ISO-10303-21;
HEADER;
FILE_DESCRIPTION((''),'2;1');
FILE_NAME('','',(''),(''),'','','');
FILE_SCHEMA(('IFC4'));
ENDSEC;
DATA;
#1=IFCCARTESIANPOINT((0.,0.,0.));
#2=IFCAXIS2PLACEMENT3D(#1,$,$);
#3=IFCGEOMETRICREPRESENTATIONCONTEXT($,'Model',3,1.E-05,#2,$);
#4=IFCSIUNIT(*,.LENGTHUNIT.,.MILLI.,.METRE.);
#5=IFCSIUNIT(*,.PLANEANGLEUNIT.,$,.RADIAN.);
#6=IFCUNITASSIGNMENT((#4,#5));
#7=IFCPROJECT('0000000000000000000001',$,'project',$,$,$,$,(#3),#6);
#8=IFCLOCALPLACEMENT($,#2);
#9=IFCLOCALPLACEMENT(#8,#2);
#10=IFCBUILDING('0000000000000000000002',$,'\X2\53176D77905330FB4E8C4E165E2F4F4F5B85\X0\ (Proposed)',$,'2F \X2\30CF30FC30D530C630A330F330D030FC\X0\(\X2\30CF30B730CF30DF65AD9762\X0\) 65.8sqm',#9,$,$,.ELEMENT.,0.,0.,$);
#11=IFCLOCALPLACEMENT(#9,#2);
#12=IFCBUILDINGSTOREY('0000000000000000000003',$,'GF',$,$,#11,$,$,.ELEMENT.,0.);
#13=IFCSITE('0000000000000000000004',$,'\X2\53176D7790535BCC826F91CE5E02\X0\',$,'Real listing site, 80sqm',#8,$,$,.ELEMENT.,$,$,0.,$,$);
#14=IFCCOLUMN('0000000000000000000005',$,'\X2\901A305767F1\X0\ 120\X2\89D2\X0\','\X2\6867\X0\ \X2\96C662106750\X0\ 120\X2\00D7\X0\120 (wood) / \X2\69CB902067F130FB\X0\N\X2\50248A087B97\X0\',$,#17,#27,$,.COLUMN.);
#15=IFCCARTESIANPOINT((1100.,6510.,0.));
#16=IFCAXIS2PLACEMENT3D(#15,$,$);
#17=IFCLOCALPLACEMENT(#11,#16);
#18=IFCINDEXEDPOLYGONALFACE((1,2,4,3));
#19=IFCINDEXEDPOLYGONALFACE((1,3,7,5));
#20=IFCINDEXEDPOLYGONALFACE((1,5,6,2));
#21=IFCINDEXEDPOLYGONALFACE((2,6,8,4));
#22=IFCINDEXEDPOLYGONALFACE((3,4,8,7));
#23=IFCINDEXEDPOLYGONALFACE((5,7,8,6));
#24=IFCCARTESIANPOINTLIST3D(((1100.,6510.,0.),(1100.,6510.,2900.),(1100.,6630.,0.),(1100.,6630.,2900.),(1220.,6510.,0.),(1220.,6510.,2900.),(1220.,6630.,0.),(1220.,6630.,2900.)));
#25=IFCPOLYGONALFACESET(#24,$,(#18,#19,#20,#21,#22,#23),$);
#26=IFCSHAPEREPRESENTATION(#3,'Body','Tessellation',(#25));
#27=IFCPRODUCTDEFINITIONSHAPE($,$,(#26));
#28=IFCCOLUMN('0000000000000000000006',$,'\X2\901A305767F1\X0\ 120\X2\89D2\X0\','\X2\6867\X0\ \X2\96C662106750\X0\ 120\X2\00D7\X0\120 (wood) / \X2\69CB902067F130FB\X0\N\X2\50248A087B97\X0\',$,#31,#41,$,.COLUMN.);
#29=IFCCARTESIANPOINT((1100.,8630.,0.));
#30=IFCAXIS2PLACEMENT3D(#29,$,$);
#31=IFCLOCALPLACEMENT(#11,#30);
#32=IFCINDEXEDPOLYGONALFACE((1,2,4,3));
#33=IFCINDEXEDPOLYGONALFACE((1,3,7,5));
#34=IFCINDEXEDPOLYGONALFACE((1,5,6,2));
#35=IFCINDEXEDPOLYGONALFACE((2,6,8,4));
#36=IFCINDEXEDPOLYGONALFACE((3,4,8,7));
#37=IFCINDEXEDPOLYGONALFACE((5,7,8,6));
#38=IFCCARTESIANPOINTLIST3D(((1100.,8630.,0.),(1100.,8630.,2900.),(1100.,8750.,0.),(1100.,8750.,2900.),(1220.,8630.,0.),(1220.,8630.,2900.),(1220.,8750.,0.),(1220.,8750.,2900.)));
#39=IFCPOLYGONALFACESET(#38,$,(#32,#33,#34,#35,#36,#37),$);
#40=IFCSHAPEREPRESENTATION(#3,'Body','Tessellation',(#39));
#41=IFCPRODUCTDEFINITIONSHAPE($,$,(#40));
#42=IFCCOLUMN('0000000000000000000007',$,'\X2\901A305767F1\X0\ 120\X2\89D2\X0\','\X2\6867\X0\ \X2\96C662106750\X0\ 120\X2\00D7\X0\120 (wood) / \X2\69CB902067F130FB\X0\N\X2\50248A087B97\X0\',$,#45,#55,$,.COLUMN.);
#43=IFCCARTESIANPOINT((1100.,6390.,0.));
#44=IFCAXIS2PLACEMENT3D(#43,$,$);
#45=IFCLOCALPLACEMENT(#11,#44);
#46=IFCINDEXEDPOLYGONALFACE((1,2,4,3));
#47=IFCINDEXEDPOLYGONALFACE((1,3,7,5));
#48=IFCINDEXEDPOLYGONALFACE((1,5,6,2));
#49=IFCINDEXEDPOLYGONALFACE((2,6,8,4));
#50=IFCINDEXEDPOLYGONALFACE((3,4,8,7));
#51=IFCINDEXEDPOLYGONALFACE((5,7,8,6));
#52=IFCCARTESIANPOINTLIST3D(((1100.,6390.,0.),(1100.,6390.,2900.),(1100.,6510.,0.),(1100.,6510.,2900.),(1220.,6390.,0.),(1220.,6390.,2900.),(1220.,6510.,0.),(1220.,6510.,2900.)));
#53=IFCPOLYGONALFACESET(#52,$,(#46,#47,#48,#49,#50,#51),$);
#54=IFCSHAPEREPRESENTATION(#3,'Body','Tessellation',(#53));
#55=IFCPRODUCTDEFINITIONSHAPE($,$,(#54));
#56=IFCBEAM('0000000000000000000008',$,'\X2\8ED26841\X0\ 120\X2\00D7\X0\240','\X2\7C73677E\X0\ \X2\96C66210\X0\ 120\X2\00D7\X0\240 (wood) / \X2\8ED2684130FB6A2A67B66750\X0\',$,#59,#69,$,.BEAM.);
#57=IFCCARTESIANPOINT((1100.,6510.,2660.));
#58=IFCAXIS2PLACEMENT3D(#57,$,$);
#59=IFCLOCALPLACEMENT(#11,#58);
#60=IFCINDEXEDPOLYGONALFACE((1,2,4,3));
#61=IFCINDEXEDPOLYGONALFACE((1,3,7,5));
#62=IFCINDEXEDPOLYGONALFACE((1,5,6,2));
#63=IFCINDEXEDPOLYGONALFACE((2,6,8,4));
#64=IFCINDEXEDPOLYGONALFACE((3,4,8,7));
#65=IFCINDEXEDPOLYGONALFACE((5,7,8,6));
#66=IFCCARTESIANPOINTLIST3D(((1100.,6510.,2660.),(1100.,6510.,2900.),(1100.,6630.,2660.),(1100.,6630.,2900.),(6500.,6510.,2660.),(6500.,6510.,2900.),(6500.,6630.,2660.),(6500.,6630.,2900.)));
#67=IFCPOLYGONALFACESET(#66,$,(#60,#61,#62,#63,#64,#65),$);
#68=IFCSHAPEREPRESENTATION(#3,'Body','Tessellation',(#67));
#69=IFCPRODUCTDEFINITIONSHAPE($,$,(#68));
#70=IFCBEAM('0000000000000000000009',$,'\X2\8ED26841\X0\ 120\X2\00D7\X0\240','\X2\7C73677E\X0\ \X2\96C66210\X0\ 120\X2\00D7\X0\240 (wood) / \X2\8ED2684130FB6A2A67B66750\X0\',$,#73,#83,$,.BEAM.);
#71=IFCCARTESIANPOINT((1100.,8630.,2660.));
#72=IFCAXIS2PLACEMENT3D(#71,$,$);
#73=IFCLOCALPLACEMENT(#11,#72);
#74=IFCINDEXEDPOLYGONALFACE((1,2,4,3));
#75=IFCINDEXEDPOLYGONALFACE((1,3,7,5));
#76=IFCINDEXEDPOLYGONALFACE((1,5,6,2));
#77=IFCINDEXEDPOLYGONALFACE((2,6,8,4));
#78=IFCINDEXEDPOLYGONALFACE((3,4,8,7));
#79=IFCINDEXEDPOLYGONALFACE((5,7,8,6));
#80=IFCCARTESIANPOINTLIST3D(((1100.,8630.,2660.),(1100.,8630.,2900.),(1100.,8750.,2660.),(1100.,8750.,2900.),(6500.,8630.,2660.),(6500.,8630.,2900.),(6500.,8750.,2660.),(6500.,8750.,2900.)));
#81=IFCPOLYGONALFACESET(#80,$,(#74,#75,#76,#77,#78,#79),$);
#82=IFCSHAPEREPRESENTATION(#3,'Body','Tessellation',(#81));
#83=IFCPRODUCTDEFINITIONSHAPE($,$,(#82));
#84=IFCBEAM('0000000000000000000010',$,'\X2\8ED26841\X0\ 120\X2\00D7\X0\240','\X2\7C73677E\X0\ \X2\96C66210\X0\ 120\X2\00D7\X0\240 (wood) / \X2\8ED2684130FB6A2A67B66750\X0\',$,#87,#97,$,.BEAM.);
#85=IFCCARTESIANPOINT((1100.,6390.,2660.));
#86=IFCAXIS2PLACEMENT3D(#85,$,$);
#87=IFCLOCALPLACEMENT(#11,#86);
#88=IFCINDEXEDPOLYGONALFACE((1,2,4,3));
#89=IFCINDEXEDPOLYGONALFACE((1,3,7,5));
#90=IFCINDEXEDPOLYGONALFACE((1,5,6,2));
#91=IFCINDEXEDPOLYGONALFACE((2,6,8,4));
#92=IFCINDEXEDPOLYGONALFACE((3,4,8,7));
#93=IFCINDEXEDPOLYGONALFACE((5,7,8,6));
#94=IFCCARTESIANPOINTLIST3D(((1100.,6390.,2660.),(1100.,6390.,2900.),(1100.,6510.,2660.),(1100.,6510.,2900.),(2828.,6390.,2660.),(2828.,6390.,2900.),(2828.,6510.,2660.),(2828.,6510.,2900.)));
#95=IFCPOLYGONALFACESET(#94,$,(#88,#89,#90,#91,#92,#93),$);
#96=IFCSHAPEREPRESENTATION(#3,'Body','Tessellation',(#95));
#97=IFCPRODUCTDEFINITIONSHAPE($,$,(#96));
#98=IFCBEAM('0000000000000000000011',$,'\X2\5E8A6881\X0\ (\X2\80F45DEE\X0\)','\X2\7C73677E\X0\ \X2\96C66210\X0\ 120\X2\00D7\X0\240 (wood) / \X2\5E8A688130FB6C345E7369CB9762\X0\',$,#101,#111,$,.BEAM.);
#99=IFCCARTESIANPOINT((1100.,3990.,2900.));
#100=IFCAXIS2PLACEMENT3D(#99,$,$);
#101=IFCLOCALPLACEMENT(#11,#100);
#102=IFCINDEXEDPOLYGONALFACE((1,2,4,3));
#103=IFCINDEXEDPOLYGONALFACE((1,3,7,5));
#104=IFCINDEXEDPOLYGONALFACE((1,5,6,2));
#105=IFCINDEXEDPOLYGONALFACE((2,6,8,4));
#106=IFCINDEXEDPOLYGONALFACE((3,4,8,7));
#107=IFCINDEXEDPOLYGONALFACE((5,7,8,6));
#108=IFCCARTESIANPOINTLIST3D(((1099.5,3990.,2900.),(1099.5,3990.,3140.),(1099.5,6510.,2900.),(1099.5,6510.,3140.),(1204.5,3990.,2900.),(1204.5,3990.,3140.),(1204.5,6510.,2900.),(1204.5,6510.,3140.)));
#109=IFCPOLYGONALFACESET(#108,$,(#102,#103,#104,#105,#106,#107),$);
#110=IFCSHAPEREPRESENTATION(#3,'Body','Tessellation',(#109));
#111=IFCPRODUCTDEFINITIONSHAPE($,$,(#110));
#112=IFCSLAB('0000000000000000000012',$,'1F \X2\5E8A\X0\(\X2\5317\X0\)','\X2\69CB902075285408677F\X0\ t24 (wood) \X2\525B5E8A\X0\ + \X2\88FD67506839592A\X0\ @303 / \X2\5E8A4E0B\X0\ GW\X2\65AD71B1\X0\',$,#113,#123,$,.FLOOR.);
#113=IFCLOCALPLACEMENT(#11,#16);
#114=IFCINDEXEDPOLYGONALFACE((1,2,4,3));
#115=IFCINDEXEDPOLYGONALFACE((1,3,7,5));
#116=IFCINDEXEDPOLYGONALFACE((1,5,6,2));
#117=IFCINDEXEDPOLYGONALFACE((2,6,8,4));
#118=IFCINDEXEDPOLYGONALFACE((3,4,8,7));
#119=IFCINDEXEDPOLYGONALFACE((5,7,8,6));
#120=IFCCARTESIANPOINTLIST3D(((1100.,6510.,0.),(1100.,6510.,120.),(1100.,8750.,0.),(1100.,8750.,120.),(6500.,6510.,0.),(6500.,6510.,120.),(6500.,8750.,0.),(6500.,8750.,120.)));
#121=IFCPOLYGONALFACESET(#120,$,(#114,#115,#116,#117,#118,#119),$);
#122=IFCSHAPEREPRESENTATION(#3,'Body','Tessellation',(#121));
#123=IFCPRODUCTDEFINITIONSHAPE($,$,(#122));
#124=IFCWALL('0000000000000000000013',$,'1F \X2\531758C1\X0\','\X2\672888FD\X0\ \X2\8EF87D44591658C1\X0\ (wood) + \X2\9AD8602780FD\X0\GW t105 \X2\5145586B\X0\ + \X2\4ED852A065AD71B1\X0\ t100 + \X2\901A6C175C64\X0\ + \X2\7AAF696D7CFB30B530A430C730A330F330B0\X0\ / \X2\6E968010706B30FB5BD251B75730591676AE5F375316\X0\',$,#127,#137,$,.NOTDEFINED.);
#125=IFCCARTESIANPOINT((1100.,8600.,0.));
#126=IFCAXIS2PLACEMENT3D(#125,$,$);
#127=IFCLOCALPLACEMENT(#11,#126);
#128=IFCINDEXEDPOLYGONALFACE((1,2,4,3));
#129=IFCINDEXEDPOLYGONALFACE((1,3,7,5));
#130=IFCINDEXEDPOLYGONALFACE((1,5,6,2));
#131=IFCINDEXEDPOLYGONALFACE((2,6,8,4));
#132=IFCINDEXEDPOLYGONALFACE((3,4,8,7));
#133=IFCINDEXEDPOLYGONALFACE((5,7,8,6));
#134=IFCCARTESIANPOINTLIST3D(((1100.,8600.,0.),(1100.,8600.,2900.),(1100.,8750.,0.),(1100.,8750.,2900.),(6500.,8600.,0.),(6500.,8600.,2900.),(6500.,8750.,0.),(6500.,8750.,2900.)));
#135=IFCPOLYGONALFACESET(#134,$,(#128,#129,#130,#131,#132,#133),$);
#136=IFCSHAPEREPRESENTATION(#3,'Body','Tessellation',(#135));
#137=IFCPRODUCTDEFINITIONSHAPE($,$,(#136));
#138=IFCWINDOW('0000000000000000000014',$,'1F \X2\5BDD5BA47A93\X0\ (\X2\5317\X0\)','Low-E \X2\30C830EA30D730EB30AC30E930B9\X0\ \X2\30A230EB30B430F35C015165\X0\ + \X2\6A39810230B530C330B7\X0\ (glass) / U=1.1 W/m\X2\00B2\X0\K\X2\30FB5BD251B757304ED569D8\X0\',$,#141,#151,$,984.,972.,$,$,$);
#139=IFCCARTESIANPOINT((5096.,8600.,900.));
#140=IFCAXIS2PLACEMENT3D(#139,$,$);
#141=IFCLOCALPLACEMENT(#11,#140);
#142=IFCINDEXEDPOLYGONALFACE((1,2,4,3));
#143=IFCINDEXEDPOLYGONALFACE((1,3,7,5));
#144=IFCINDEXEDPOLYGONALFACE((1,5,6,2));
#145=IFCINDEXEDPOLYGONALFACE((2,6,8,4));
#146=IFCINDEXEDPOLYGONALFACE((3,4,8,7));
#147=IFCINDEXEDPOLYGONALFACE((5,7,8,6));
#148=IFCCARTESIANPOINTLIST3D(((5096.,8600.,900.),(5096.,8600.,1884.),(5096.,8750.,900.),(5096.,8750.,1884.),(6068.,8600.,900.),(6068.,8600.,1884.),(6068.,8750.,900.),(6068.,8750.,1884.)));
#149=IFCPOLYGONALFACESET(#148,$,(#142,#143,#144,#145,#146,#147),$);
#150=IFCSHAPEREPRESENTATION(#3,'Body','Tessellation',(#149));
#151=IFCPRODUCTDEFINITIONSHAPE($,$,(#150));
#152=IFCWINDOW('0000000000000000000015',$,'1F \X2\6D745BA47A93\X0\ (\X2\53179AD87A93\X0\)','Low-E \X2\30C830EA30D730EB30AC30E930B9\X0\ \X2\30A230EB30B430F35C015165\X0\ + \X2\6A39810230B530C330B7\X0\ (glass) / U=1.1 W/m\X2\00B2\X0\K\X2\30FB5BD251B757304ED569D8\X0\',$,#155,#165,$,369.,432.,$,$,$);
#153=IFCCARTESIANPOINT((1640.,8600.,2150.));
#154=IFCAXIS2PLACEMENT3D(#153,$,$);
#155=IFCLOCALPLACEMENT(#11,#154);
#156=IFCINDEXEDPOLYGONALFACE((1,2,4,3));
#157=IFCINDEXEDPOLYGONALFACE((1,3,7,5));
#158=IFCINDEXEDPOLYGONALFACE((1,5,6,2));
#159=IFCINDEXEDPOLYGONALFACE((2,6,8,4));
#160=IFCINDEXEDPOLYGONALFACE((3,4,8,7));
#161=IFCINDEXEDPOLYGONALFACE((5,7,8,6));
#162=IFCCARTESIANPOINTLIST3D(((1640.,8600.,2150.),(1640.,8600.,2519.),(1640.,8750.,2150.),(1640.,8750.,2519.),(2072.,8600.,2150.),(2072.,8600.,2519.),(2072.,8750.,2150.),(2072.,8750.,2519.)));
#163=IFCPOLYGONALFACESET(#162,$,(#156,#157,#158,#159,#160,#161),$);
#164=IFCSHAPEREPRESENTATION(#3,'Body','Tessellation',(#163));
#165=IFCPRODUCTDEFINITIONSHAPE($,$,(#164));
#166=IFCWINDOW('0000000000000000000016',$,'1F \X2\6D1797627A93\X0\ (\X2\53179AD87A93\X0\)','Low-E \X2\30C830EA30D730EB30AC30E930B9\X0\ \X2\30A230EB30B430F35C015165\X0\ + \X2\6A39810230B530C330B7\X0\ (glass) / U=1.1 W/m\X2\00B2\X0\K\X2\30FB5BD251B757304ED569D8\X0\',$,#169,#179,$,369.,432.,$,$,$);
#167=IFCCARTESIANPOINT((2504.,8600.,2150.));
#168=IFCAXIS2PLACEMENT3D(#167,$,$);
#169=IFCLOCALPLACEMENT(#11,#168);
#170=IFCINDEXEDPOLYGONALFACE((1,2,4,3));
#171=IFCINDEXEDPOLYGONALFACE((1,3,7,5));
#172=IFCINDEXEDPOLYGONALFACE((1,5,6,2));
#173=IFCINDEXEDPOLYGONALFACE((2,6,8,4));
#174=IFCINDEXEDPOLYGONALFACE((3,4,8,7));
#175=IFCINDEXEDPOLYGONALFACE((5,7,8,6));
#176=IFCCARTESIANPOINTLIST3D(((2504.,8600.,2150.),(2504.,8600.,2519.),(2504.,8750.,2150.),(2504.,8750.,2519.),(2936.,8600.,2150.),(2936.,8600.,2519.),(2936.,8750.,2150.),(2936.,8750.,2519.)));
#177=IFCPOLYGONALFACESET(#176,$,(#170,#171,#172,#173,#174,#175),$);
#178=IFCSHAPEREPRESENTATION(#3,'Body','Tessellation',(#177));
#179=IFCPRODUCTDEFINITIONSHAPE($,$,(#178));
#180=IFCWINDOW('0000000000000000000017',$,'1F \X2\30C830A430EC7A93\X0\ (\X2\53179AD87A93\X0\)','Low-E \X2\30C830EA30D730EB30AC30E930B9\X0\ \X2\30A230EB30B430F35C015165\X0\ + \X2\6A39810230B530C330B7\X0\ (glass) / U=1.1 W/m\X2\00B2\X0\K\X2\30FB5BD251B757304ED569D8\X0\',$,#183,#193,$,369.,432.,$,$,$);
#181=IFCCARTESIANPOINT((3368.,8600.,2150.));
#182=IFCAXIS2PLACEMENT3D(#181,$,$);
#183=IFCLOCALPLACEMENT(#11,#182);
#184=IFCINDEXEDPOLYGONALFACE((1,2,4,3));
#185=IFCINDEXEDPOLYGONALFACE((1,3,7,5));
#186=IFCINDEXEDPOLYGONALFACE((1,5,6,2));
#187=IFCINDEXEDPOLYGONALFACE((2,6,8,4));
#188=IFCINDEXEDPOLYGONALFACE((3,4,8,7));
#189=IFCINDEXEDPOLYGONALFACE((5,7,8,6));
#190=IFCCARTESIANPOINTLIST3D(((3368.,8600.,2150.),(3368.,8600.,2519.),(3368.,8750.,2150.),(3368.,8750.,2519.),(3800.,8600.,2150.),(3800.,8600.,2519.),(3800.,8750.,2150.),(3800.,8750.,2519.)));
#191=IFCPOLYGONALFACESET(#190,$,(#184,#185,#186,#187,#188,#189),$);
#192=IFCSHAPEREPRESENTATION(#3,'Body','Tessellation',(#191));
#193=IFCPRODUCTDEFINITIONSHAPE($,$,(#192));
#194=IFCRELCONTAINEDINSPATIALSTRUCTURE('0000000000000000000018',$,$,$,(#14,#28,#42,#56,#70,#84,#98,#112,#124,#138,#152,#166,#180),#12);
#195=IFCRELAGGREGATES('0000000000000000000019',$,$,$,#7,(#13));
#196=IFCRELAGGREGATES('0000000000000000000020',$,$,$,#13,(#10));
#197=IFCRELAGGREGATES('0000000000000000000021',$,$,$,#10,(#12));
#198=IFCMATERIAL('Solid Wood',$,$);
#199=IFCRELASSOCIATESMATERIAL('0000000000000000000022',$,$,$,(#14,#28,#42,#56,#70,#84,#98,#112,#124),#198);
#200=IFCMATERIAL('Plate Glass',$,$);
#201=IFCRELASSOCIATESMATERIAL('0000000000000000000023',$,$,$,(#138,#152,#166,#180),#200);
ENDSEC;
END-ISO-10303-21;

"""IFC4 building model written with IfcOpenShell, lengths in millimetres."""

from ifc_helpers import new_model, si_unit, frame, frame_2d, origin, place, context, project, spatial, rectangle, extrude, material, element, fill, save


model = new_model("IFC4")

# Units and contexts
model_context = context("Model", 3, precision=1e-05, world=origin())
ifc_project = project(units=[si_unit("LENGTHUNIT", "METRE", prefix="MILLI"), si_unit("PLANEANGLEUNIT", "RADIAN")], contexts=[model_context])

# Site, building, storey
site_placement = place(None, origin())
site = spatial("IfcSite", under=ifc_project, at=site_placement, Name="北海道富良野市", ObjectType="Real listing site, 80sqm", CompositionType="ELEMENT", RefElevation=0.0)
building_placement = place(site_placement, origin())
building = spatial("IfcBuilding", under=site, at=building_placement, Name="北海道・二世帯住宅 (Proposed)", ObjectType="2F ハーフティンバー(ハシハミ断面) 65.8sqm", CompositionType="ELEMENT", ElevationOfRefHeight=0.0, ElevationOfTerrain=0.0)
storey_placement = place(building_placement, origin())
storey = spatial("IfcBuildingStorey", under=building, at=storey_placement, Name="GF", CompositionType="ELEMENT", Elevation=0.0)

# Columns
ifc_material_1 = material(Name="Solid Wood")
column_1_placement = place(storey_placement, frame((1100.0, 6510.0, 0.0)))
element("IfcColumn", 1, at=column_1_placement, inside=storey, material=ifc_material_1, Name="通し柱 120角", Description="桧 集成材 120×120 (wood) / 構造柱・N値計算", PredefinedType="COLUMN", context=model_context, shape_type="SweptSolid", body=[
    extrude(rectangle(XDim=120.0, YDim=120.0, at=frame_2d((60.0, 60.0))), frame((1100.0, 6510.0, 0.0)), (0.0, 0.0, 1.0), 2900.0),
])
column_2_placement = place(storey_placement, frame((1100.0, 8630.0, 0.0)))
element("IfcColumn", 2, at=column_2_placement, inside=storey, material=ifc_material_1, Name="通し柱 120角", Description="桧 集成材 120×120 (wood) / 構造柱・N値計算", PredefinedType="COLUMN", context=model_context, shape_type="SweptSolid", body=[
    extrude(rectangle(XDim=120.0, YDim=120.0, at=frame_2d((60.0, 60.0))), frame((1100.0, 8630.0, 0.0)), (0.0, 0.0, 1.0), 2900.0),
])
column_3_placement = place(storey_placement, frame((1100.0, 6390.0, 0.0)))
element("IfcColumn", 3, at=column_3_placement, inside=storey, material=ifc_material_1, Name="通し柱 120角", Description="桧 集成材 120×120 (wood) / 構造柱・N値計算", PredefinedType="COLUMN", context=model_context, shape_type="SweptSolid", body=[
    extrude(rectangle(XDim=120.0, YDim=120.0, at=frame_2d((60.0, 60.0))), frame((1100.0, 6390.0, 0.0)), (0.0, 0.0, 1.0), 2900.0),
])

# Beams
beam_1_placement = place(storey_placement, frame((1100.0, 6510.0, 2660.0)))
element("IfcBeam", 4, at=beam_1_placement, inside=storey, material=ifc_material_1, Name="軒桁 120×240", Description="米松 集成 120×240 (wood) / 軒桁・横架材", PredefinedType="BEAM", context=model_context, shape_type="SweptSolid", body=[
    extrude(rectangle(XDim=5400.0, YDim=120.0, at=frame_2d((2700.0, 60.0))), frame((1100.0, 6510.0, 2660.0)), (0.0, 0.0, 1.0), 240.0),
])
beam_2_placement = place(storey_placement, frame((1100.0, 8630.0, 2660.0)))
element("IfcBeam", 5, at=beam_2_placement, inside=storey, material=ifc_material_1, Name="軒桁 120×240", Description="米松 集成 120×240 (wood) / 軒桁・横架材", PredefinedType="BEAM", context=model_context, shape_type="SweptSolid", body=[
    extrude(rectangle(XDim=5400.0, YDim=120.0, at=frame_2d((2700.0, 60.0))), frame((1100.0, 8630.0, 2660.0)), (0.0, 0.0, 1.0), 240.0),
])
beam_3_placement = place(storey_placement, frame((1100.0, 6390.0, 2660.0)))
element("IfcBeam", 6, at=beam_3_placement, inside=storey, material=ifc_material_1, Name="軒桁 120×240", Description="米松 集成 120×240 (wood) / 軒桁・横架材", PredefinedType="BEAM", context=model_context, shape_type="SweptSolid", body=[
    extrude(rectangle(XDim=1728.0, YDim=120.0, at=frame_2d((864.0, 60.0))), frame((1100.0, 6390.0, 2660.0)), (0.0, 0.0, 1.0), 240.0),
])
beam_4_placement = place(storey_placement, frame((1100.0, 3990.0, 2900.0)))
element("IfcBeam", 7, at=beam_4_placement, inside=storey, material=ifc_material_1, Name="床梁 (胴差)", Description="米松 集成 120×240 (wood) / 床梁・水平構面", PredefinedType="BEAM", context=model_context, shape_type="SweptSolid", body=[
    extrude(rectangle(XDim=105.0, YDim=2520.0, at=frame_2d((52.0, 1260.0))), frame((1100.0, 3990.0, 2900.0)), (0.0, 0.0, 1.0), 240.0),
])

# Slab
slab_placement = place(storey_placement, frame((1100.0, 6510.0, 0.0)))
element("IfcSlab", 8, at=slab_placement, inside=storey, material=ifc_material_1, Name="1F 床(北)", Description="構造用合板 t24 (wood) 剛床 + 製材根太 @303 / 床下 GW断熱", PredefinedType="FLOOR", context=model_context, shape_type="SweptSolid", body=[
    extrude(rectangle(XDim=5400.0, YDim=2240.0, at=frame_2d((2700.0, 1120.0))), frame((1100.0, 6510.0, 0.0)), (0.0, 0.0, 1.0), 120.0),
])

# Wall, openings, windows
wall_1_placement = place(storey_placement, frame((1100.0, 8600.0, 0.0)))
wall_1 = element("IfcWall", 9, at=wall_1_placement, inside=storey, material=ifc_material_1, Name="1F 北壁", Description="木製 軸組外壁 (wood) + 高性能GW t105 充填 + 付加断熱 t100 + 通気層 + 窯業系サイディング / 準耐火・寒冷地外皮強化", PredefinedType="NOTDEFINED", context=model_context, shape_type="SweptSolid", body=[
    extrude(rectangle(XDim=5400.0, YDim=150.0, at=frame_2d((2700.0, 75.0))), frame((1100.0, 8600.0, 0.0)), (0.0, 0.0, 1.0), 2900.0),
])
opening_1_placement = place(storey_placement, frame((5096.0, 8600.0, 900.0)))
opening_1 = element("IfcOpeningElement", 10, at=opening_1_placement, cuts=wall_1, PredefinedType="NOTDEFINED", context=model_context, shape_type="SweptSolid", body=[
    extrude(rectangle(XDim=972.0, YDim=150.0, at=frame_2d((486.0, 75.0))), frame((5096.0, 8600.0, 900.0)), (0.0, 0.0, 1.0), 984.0),
])
opening_2_placement = place(storey_placement, frame((1640.0, 8600.0, 2150.0)))
opening_2 = element("IfcOpeningElement", 11, at=opening_2_placement, cuts=wall_1, PredefinedType="NOTDEFINED", context=model_context, shape_type="SweptSolid", body=[
    extrude(rectangle(XDim=432.0, YDim=150.0, at=frame_2d((216.0, 75.0))), frame((1640.0, 8600.0, 2150.0)), (0.0, 0.0, 1.0), 369.0),
])
opening_3_placement = place(storey_placement, frame((2504.0, 8600.0, 2150.0)))
opening_3 = element("IfcOpeningElement", 12, at=opening_3_placement, cuts=wall_1, PredefinedType="NOTDEFINED", context=model_context, shape_type="SweptSolid", body=[
    extrude(rectangle(XDim=432.0, YDim=150.0, at=frame_2d((216.0, 75.0))), frame((2504.0, 8600.0, 2150.0)), (0.0, 0.0, 1.0), 369.0),
])
opening_4_placement = place(storey_placement, frame((3368.0, 8600.0, 2150.0)))
opening_4 = element("IfcOpeningElement", 13, at=opening_4_placement, cuts=wall_1, PredefinedType="NOTDEFINED", context=model_context, shape_type="SweptSolid", body=[
    extrude(rectangle(XDim=432.0, YDim=150.0, at=frame_2d((216.0, 75.0))), frame((3368.0, 8600.0, 2150.0)), (0.0, 0.0, 1.0), 369.0),
])
ifc_material_2 = material(Name="Plate Glass")
window_1_placement = place(storey_placement, frame((5096.0, 8600.0, 900.0)))
window_1 = element("IfcWindow", 14, at=window_1_placement, inside=storey, material=ifc_material_2, Name="1F 寝室窓 (北)", Description="Low-E トリプルガラス アルゴン封入 + 樹脂サッシ (glass) / U=1.1 W/m²K・寒冷地仕様", OverallHeight=984.0, OverallWidth=972.0, context=model_context, shape_type="SweptSolid", body=[
    extrude(rectangle(XDim=972.0, YDim=150.0, at=frame_2d((486.0, 75.0))), frame((5096.0, 8600.0, 900.0)), (0.0, 0.0, 1.0), 984.0),
])
fill(opening_1, window_1)
window_2_placement = place(storey_placement, frame((1640.0, 8600.0, 2150.0)))
window_2 = element("IfcWindow", 15, at=window_2_placement, inside=storey, material=ifc_material_2, Name="1F 浴室窓 (北高窓)", Description="Low-E トリプルガラス アルゴン封入 + 樹脂サッシ (glass) / U=1.1 W/m²K・寒冷地仕様", OverallHeight=369.0, OverallWidth=432.0, context=model_context, shape_type="SweptSolid", body=[
    extrude(rectangle(XDim=432.0, YDim=150.0, at=frame_2d((216.0, 75.0))), frame((1640.0, 8600.0, 2150.0)), (0.0, 0.0, 1.0), 369.0),
])
fill(opening_2, window_2)
window_3_placement = place(storey_placement, frame((2504.0, 8600.0, 2150.0)))
window_3 = element("IfcWindow", 16, at=window_3_placement, inside=storey, material=ifc_material_2, Name="1F 洗面窓 (北高窓)", Description="Low-E トリプルガラス アルゴン封入 + 樹脂サッシ (glass) / U=1.1 W/m²K・寒冷地仕様", OverallHeight=369.0, OverallWidth=432.0, context=model_context, shape_type="SweptSolid", body=[
    extrude(rectangle(XDim=432.0, YDim=150.0, at=frame_2d((216.0, 75.0))), frame((2504.0, 8600.0, 2150.0)), (0.0, 0.0, 1.0), 369.0),
])
fill(opening_3, window_3)
window_4_placement = place(storey_placement, frame((3368.0, 8600.0, 2150.0)))
window_4 = element("IfcWindow", 17, at=window_4_placement, inside=storey, material=ifc_material_2, Name="1F トイレ窓 (北高窓)", Description="Low-E トリプルガラス アルゴン封入 + 樹脂サッシ (glass) / U=1.1 W/m²K・寒冷地仕様", OverallHeight=369.0, OverallWidth=432.0, context=model_context, shape_type="SweptSolid", body=[
    extrude(rectangle(XDim=432.0, YDim=150.0, at=frame_2d((216.0, 75.0))), frame((3368.0, 8600.0, 2150.0)), (0.0, 0.0, 1.0), 369.0),
])
fill(opening_4, window_4)

save(model, "model.ifc")
